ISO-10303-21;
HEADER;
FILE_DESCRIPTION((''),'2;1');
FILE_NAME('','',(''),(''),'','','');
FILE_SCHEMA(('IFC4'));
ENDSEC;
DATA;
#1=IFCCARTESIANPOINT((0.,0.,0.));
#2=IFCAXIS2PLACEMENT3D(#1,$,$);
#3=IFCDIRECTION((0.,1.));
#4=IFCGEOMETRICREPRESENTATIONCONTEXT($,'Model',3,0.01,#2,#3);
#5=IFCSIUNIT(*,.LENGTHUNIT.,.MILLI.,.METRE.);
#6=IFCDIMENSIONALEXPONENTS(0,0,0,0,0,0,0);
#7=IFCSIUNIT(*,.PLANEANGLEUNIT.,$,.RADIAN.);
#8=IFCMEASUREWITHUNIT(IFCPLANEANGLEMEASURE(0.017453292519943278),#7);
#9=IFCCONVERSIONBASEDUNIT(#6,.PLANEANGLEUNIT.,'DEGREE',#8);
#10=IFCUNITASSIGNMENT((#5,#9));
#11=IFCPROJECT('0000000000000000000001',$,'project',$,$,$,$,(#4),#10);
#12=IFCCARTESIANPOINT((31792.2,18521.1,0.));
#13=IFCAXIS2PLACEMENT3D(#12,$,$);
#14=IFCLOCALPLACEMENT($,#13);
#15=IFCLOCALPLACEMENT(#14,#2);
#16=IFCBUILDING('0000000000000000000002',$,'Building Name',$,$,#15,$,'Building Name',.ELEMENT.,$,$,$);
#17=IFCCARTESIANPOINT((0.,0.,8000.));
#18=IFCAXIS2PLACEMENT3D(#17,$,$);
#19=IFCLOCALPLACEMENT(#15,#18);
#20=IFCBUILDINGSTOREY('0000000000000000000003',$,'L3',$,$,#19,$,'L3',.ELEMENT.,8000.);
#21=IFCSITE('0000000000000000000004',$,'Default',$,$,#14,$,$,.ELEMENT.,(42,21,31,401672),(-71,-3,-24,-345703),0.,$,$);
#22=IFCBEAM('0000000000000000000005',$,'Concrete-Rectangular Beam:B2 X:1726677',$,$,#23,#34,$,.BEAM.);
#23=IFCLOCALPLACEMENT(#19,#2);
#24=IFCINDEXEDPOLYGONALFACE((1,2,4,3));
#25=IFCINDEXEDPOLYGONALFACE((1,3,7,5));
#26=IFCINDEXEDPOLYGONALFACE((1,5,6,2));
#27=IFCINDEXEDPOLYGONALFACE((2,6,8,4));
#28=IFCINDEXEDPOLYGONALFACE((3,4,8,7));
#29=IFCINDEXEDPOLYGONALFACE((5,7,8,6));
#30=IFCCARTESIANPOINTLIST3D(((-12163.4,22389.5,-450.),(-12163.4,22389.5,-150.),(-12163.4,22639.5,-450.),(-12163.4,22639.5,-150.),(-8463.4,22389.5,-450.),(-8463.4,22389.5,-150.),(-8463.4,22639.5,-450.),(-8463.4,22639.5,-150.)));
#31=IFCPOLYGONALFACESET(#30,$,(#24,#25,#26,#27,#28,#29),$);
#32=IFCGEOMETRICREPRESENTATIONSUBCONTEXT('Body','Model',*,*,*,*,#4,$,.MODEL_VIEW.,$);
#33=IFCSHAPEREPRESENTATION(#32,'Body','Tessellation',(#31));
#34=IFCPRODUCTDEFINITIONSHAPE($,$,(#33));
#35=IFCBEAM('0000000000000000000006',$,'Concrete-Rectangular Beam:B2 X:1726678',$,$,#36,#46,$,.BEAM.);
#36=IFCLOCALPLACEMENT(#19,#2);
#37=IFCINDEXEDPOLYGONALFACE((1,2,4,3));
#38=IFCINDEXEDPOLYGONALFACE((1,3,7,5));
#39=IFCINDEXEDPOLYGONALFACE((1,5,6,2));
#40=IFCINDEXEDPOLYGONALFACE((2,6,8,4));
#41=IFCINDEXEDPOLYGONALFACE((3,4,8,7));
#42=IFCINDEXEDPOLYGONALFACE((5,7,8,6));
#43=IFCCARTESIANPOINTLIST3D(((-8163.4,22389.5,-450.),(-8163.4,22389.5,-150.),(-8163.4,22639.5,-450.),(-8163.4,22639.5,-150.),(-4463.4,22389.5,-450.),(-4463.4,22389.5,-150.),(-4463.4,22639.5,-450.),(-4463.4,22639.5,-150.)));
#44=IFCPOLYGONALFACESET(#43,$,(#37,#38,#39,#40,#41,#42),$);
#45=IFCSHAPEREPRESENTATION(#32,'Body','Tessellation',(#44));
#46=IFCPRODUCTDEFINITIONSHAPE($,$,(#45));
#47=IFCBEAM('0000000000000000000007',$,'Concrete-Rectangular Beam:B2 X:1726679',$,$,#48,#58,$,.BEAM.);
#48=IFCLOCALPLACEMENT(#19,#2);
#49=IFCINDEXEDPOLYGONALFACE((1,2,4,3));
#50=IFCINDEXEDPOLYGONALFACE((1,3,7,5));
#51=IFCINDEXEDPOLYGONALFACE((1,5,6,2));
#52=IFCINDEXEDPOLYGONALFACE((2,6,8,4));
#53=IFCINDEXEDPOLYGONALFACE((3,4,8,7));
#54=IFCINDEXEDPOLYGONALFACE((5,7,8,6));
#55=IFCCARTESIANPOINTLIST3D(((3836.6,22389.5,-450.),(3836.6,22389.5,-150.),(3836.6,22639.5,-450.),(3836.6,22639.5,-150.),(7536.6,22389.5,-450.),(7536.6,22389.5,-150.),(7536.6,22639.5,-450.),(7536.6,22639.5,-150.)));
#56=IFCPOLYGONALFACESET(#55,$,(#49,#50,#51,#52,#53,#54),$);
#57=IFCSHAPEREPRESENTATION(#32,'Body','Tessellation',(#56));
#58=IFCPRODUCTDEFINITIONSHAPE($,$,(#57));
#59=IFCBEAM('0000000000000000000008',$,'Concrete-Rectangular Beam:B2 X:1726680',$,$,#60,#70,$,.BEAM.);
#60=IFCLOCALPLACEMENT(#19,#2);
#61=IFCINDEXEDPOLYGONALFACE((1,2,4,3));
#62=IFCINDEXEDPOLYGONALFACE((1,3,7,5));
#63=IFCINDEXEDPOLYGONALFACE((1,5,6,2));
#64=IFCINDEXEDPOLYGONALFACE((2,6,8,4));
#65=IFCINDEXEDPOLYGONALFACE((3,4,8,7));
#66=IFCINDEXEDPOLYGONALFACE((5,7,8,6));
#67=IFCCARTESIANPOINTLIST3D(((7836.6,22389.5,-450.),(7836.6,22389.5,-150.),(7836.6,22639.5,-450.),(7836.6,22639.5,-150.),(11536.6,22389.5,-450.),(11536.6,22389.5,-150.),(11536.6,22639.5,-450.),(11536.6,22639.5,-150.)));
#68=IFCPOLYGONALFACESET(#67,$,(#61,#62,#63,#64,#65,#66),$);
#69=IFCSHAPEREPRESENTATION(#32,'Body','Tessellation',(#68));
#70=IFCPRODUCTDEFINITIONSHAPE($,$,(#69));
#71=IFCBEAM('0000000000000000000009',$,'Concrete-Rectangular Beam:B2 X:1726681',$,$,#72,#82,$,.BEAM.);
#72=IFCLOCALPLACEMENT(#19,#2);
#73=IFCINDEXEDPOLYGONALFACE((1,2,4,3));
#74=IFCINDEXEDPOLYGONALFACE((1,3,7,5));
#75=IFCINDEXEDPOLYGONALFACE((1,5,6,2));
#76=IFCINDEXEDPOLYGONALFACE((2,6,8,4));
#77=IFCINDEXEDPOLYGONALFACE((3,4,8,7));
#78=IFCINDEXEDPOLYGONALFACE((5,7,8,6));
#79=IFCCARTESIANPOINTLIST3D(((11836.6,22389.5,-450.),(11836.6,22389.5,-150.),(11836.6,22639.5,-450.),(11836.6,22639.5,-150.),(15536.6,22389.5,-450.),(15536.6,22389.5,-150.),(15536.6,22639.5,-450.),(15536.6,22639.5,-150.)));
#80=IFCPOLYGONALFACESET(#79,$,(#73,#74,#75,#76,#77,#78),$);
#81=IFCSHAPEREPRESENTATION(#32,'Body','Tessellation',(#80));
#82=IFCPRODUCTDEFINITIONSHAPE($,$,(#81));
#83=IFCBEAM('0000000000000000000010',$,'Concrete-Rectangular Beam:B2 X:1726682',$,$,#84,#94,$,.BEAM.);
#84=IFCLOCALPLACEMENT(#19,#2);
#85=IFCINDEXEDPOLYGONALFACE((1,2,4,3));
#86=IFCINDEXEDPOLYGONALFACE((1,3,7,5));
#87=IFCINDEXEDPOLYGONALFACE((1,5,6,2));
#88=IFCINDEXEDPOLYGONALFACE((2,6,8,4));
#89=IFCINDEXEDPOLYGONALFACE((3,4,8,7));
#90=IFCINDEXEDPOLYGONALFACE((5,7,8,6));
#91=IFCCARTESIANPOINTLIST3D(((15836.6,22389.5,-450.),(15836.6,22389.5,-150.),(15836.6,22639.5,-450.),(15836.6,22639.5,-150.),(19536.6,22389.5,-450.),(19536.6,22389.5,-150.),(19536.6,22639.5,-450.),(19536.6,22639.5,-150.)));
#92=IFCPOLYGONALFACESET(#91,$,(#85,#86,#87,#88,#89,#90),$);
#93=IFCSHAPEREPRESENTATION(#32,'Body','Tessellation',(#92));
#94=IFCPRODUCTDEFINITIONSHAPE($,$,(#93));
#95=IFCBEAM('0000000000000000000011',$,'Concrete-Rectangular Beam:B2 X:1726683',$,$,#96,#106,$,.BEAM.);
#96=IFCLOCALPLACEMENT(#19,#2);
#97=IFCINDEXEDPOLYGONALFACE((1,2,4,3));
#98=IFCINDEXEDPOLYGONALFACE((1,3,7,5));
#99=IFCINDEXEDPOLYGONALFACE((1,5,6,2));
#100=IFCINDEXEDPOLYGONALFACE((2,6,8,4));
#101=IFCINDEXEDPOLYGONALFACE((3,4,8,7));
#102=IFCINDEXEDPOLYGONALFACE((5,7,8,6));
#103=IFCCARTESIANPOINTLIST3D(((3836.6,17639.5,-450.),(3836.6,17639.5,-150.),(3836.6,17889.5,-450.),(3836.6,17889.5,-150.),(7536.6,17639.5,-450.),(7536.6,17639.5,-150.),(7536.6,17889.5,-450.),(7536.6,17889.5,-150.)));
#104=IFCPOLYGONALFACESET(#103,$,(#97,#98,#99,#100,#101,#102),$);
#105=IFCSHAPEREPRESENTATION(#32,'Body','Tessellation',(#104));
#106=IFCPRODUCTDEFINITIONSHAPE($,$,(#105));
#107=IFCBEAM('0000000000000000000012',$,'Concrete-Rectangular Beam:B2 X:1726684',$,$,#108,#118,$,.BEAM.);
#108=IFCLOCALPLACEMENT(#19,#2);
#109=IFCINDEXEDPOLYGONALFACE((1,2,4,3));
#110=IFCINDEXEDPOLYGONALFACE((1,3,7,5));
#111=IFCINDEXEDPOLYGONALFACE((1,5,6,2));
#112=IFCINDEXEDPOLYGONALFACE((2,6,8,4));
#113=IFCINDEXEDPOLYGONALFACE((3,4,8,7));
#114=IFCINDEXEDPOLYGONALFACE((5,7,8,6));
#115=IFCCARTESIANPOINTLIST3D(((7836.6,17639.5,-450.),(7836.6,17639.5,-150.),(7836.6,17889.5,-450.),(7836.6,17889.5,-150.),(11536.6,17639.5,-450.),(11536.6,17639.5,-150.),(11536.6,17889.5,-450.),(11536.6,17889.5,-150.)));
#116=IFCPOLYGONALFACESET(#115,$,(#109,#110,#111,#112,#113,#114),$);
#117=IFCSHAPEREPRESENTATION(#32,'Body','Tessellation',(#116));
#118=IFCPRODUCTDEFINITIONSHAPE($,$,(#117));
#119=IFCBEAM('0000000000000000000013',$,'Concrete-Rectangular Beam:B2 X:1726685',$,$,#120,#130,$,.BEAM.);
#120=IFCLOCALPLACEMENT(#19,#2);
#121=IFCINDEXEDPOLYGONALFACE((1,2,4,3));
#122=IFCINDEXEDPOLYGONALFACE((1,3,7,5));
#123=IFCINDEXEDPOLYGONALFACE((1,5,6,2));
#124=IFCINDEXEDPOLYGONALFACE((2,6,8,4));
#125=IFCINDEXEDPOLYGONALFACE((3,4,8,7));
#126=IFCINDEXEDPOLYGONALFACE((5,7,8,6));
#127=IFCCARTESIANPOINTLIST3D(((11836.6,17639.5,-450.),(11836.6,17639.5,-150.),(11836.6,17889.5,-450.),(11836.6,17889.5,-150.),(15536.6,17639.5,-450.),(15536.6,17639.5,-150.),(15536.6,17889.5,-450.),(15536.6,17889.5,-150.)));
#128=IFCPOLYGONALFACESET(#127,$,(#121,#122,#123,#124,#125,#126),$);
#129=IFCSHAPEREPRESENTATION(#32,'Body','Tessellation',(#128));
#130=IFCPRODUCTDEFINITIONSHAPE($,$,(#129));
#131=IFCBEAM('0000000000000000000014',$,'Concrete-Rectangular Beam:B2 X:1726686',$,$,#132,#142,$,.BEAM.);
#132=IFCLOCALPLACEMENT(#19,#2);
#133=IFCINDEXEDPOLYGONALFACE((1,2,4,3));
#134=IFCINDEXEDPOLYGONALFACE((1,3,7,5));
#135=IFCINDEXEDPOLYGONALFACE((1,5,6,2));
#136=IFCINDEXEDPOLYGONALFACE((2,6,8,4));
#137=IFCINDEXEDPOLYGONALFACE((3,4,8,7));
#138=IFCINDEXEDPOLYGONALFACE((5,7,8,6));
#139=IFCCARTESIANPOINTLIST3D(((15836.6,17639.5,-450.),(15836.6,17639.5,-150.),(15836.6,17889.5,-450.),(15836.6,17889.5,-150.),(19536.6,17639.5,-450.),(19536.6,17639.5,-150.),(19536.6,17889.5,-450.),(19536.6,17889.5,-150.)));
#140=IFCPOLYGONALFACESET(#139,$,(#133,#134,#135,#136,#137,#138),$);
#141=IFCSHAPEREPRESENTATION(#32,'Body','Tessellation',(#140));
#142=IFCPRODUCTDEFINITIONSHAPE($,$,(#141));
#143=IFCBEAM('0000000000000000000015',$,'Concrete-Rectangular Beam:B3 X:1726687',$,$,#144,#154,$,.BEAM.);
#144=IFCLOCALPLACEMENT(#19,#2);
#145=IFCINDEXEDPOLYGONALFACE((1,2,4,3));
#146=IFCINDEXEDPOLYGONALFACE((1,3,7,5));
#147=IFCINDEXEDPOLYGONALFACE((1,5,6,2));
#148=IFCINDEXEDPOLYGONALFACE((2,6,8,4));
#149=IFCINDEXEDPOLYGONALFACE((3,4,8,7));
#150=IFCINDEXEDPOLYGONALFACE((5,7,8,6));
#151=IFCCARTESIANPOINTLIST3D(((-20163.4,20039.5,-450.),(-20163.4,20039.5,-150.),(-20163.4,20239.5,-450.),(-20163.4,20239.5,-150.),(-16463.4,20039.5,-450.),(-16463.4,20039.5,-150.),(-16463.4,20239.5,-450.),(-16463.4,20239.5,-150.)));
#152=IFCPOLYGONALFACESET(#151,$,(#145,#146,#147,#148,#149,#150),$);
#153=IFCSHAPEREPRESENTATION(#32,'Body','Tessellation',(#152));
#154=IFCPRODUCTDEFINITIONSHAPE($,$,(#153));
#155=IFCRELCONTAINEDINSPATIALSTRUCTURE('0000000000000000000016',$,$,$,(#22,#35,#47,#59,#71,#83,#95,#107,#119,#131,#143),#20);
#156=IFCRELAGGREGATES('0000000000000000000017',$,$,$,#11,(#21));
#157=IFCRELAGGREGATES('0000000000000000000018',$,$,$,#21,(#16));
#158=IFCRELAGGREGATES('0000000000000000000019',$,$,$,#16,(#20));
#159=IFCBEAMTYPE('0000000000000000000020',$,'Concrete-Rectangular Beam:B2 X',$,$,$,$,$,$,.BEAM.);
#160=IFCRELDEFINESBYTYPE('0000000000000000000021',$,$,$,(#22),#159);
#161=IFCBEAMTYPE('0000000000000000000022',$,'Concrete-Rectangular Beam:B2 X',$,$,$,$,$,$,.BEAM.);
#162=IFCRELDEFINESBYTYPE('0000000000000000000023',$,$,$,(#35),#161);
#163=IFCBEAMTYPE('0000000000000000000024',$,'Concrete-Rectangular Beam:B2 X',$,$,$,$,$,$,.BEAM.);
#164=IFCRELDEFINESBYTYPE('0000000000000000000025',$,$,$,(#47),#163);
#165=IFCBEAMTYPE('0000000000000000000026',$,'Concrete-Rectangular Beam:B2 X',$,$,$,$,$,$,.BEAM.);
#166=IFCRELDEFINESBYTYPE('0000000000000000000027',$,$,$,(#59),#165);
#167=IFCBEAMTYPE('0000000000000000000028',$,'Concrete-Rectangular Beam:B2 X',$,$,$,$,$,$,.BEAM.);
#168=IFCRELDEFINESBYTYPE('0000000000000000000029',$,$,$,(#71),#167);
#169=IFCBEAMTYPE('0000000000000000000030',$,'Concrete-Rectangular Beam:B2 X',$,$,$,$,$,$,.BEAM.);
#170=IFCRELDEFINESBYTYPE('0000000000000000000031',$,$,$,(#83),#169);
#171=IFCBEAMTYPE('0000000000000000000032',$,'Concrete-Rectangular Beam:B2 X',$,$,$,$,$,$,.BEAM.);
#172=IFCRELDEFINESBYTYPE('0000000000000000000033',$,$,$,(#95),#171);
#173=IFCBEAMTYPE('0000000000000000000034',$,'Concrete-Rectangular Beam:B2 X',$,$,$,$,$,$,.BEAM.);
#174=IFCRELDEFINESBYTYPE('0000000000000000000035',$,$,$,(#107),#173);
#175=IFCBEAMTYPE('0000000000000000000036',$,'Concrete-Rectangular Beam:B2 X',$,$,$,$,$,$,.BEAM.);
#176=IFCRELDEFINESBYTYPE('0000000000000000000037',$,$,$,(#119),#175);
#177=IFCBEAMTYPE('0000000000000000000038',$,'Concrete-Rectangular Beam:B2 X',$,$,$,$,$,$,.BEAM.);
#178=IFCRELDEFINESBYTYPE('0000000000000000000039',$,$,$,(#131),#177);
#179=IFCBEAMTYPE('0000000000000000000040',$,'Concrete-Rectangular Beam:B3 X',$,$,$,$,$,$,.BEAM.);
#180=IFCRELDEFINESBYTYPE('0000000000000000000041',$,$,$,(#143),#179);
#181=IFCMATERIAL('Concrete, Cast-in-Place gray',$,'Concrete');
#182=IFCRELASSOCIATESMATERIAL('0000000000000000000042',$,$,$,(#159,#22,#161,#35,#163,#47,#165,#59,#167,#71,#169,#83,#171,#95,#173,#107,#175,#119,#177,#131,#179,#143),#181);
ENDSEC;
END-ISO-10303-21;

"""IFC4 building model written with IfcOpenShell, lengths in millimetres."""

from ifc_helpers import new_model, entity, si_unit, converted_unit, direction, frame, origin, place, context, subcontext, project, spatial, indexed_curve, outline, extrude, source, transform, mapped, material, type_object, type_shapes, element, save


model = new_model("IFC4")

# Units and contexts
model_context = context("Model", 3, precision=0.01, world=origin(), true_north=direction((0.0, 1.0)))
body_context = subcontext(model_context, "Body", "Model", "MODEL_VIEW")
ifc_project = project(units=[si_unit("LENGTHUNIT", "METRE", prefix="MILLI"), converted_unit("PLANEANGLEUNIT", "DEGREE", entity("IfcPlaneAngleMeasure", 0.017453292519943278), si_unit("PLANEANGLEUNIT", "RADIAN"), dimensions=[0, 0, 0, 0, 0, 0, 0])], contexts=[model_context])

# Site, building, storey
site_placement = place(None, frame((31792.2, 18521.1, 0.0)))
site = spatial("IfcSite", under=ifc_project, at=site_placement, Name="Default", CompositionType="ELEMENT", RefLatitude=(42, 21, 31, 401672), RefLongitude=(-71, -3, -24, -345703), RefElevation=0.0)
building_placement = place(site_placement, origin())
building = spatial("IfcBuilding", under=site, at=building_placement, Name="Building Name", LongName="Building Name", CompositionType="ELEMENT")
storey_placement = place(building_placement, frame((0.0, 0.0, 8000.0)))
storey = spatial("IfcBuildingStorey", under=building, at=storey_placement, Name="L3", LongName="L3", CompositionType="ELEMENT", Elevation=8000.0)

# Beams
ifc_material = material(Name="Concrete, Cast-in-Place gray", Category="Concrete")
beam_type_1 = type_object("IfcBeamType", Name="Concrete-Rectangular Beam:B2 X", PredefinedType="BEAM", material=ifc_material)
shared_shape_1 = source(origin(), body_context, "Body", "SweptSolid", [
    extrude(outline(indexed_curve([(-150.0, -125.0), (150.0, -125.0), (150.0, 125.0), (-150.0, 125.0), (-150.0, -125.0)], self_intersect=False)), frame((-12163.4, 22514.5, 7700.0), z_axis=(1.0, 0.0, 0.0), x_axis=(0.0, 0.0, -1.0)), (0.0, 0.0, 1.0), 3700.0),
])
type_shapes(beam_type_1, [shared_shape_1])
beam_1_placement = place(storey_placement, frame((0.0, 0.0, -8000.0)))
element("IfcBeam", 1, at=beam_1_placement, inside=storey, type_object=beam_type_1, material=ifc_material, Name="Concrete-Rectangular Beam:B2 X:1726677", PredefinedType="BEAM", context=body_context, shape_type="MappedRepresentation", body=[
    mapped(shared_shape_1, transform((0.0, 0.0, 0.0), scale=1.0)),
])
beam_type_2 = type_object("IfcBeamType", Name="Concrete-Rectangular Beam:B2 X", PredefinedType="BEAM", material=ifc_material)
shared_shape_2 = source(origin(), body_context, "Body", "SweptSolid", [
    extrude(outline(indexed_curve([(-150.0, -125.0), (150.0, -125.0), (150.0, 125.0), (-150.0, 125.0), (-150.0, -125.0)], self_intersect=False)), frame((-8163.4, 22514.5, 7700.0), z_axis=(1.0, 0.0, 0.0), x_axis=(0.0, 0.0, -1.0)), (0.0, 0.0, 1.0), 3700.0),
])
type_shapes(beam_type_2, [shared_shape_2])
beam_2_placement = place(storey_placement, frame((0.0, 0.0, -8000.0)))
element("IfcBeam", 2, at=beam_2_placement, inside=storey, type_object=beam_type_2, material=ifc_material, Name="Concrete-Rectangular Beam:B2 X:1726678", PredefinedType="BEAM", context=body_context, shape_type="MappedRepresentation", body=[
    mapped(shared_shape_2, transform((0.0, 0.0, 0.0), scale=1.0)),
])
beam_type_3 = type_object("IfcBeamType", Name="Concrete-Rectangular Beam:B2 X", PredefinedType="BEAM", material=ifc_material)
shared_shape_3 = source(origin(), body_context, "Body", "SweptSolid", [
    extrude(outline(indexed_curve([(-150.0, -125.0), (150.0, -125.0), (150.0, 125.0), (-150.0, 125.0), (-150.0, -125.0)], self_intersect=False)), frame((3836.6, 22514.5, 7700.0), z_axis=(1.0, 0.0, 0.0), x_axis=(0.0, 0.0, -1.0)), (0.0, 0.0, 1.0), 3700.0),
])
type_shapes(beam_type_3, [shared_shape_3])
beam_3_placement = place(storey_placement, frame((0.0, 0.0, -8000.0)))
element("IfcBeam", 3, at=beam_3_placement, inside=storey, type_object=beam_type_3, material=ifc_material, Name="Concrete-Rectangular Beam:B2 X:1726679", PredefinedType="BEAM", context=body_context, shape_type="MappedRepresentation", body=[
    mapped(shared_shape_3, transform((0.0, 0.0, 0.0), scale=1.0)),
])
beam_type_4 = type_object("IfcBeamType", Name="Concrete-Rectangular Beam:B2 X", PredefinedType="BEAM", material=ifc_material)
shared_shape_4 = source(origin(), body_context, "Body", "SweptSolid", [
    extrude(outline(indexed_curve([(-150.0, -125.0), (150.0, -125.0), (150.0, 125.0), (-150.0, 125.0), (-150.0, -125.0)], self_intersect=False)), frame((7836.6, 22514.5, 7700.0), z_axis=(1.0, 0.0, 0.0), x_axis=(0.0, 0.0, -1.0)), (0.0, 0.0, 1.0), 3700.0),
])
type_shapes(beam_type_4, [shared_shape_4])
beam_4_placement = place(storey_placement, frame((0.0, 0.0, -8000.0)))
element("IfcBeam", 4, at=beam_4_placement, inside=storey, type_object=beam_type_4, material=ifc_material, Name="Concrete-Rectangular Beam:B2 X:1726680", PredefinedType="BEAM", context=body_context, shape_type="MappedRepresentation", body=[
    mapped(shared_shape_4, transform((0.0, 0.0, 0.0), scale=1.0)),
])
beam_type_5 = type_object("IfcBeamType", Name="Concrete-Rectangular Beam:B2 X", PredefinedType="BEAM", material=ifc_material)
shared_shape_5 = source(origin(), body_context, "Body", "SweptSolid", [
    extrude(outline(indexed_curve([(-150.0, -125.0), (150.0, -125.0), (150.0, 125.0), (-150.0, 125.0), (-150.0, -125.0)], self_intersect=False)), frame((11836.6, 22514.5, 7700.0), z_axis=(1.0, 0.0, 0.0), x_axis=(0.0, 0.0, -1.0)), (0.0, 0.0, 1.0), 3700.0),
])
type_shapes(beam_type_5, [shared_shape_5])
beam_5_placement = place(storey_placement, frame((0.0, 0.0, -8000.0)))
element("IfcBeam", 5, at=beam_5_placement, inside=storey, type_object=beam_type_5, material=ifc_material, Name="Concrete-Rectangular Beam:B2 X:1726681", PredefinedType="BEAM", context=body_context, shape_type="MappedRepresentation", body=[
    mapped(shared_shape_5, transform((0.0, 0.0, 0.0), scale=1.0)),
])
beam_type_6 = type_object("IfcBeamType", Name="Concrete-Rectangular Beam:B2 X", PredefinedType="BEAM", material=ifc_material)
shared_shape_6 = source(origin(), body_context, "Body", "SweptSolid", [
    extrude(outline(indexed_curve([(-150.0, -125.0), (150.0, -125.0), (150.0, 125.0), (-150.0, 125.0), (-150.0, -125.0)], self_intersect=False)), frame((15836.6, 22514.5, 7700.0), z_axis=(1.0, 0.0, 0.0), x_axis=(0.0, 0.0, -1.0)), (0.0, 0.0, 1.0), 3700.0),
])
type_shapes(beam_type_6, [shared_shape_6])
beam_6_placement = place(storey_placement, frame((0.0, 0.0, -8000.0)))
element("IfcBeam", 6, at=beam_6_placement, inside=storey, type_object=beam_type_6, material=ifc_material, Name="Concrete-Rectangular Beam:B2 X:1726682", PredefinedType="BEAM", context=body_context, shape_type="MappedRepresentation", body=[
    mapped(shared_shape_6, transform((0.0, 0.0, 0.0), scale=1.0)),
])
beam_type_7 = type_object("IfcBeamType", Name="Concrete-Rectangular Beam:B2 X", PredefinedType="BEAM", material=ifc_material)
shared_shape_7 = source(origin(), body_context, "Body", "SweptSolid", [
    extrude(outline(indexed_curve([(-150.0, -125.0), (150.0, -125.0), (150.0, 125.0), (-150.0, 125.0), (-150.0, -125.0)], self_intersect=False)), frame((3836.6, 17764.5, 7700.0), z_axis=(1.0, 0.0, 0.0), x_axis=(0.0, 0.0, -1.0)), (0.0, 0.0, 1.0), 3700.0),
])
type_shapes(beam_type_7, [shared_shape_7])
beam_7_placement = place(storey_placement, frame((0.0, 0.0, -8000.0)))
element("IfcBeam", 7, at=beam_7_placement, inside=storey, type_object=beam_type_7, material=ifc_material, Name="Concrete-Rectangular Beam:B2 X:1726683", PredefinedType="BEAM", context=body_context, shape_type="MappedRepresentation", body=[
    mapped(shared_shape_7, transform((0.0, 0.0, 0.0), scale=1.0)),
])
beam_type_8 = type_object("IfcBeamType", Name="Concrete-Rectangular Beam:B2 X", PredefinedType="BEAM", material=ifc_material)
shared_shape_8 = source(origin(), body_context, "Body", "SweptSolid", [
    extrude(outline(indexed_curve([(-150.0, -125.0), (150.0, -125.0), (150.0, 125.0), (-150.0, 125.0), (-150.0, -125.0)], self_intersect=False)), frame((7836.6, 17764.5, 7700.0), z_axis=(1.0, 0.0, 0.0), x_axis=(0.0, 0.0, -1.0)), (0.0, 0.0, 1.0), 3700.0),
])
type_shapes(beam_type_8, [shared_shape_8])
beam_8_placement = place(storey_placement, frame((0.0, 0.0, -8000.0)))
element("IfcBeam", 8, at=beam_8_placement, inside=storey, type_object=beam_type_8, material=ifc_material, Name="Concrete-Rectangular Beam:B2 X:1726684", PredefinedType="BEAM", context=body_context, shape_type="MappedRepresentation", body=[
    mapped(shared_shape_8, transform((0.0, 0.0, 0.0), scale=1.0)),
])
beam_type_9 = type_object("IfcBeamType", Name="Concrete-Rectangular Beam:B2 X", PredefinedType="BEAM", material=ifc_material)
shared_shape_9 = source(origin(), body_context, "Body", "SweptSolid", [
    extrude(outline(indexed_curve([(-150.0, -125.0), (150.0, -125.0), (150.0, 125.0), (-150.0, 125.0), (-150.0, -125.0)], self_intersect=False)), frame((11836.6, 17764.5, 7700.0), z_axis=(1.0, 0.0, 0.0), x_axis=(0.0, 0.0, -1.0)), (0.0, 0.0, 1.0), 3700.0),
])
type_shapes(beam_type_9, [shared_shape_9])
beam_9_placement = place(storey_placement, frame((0.0, 0.0, -8000.0)))
element("IfcBeam", 9, at=beam_9_placement, inside=storey, type_object=beam_type_9, material=ifc_material, Name="Concrete-Rectangular Beam:B2 X:1726685", PredefinedType="BEAM", context=body_context, shape_type="MappedRepresentation", body=[
    mapped(shared_shape_9, transform((0.0, 0.0, 0.0), scale=1.0)),
])
beam_type_10 = type_object("IfcBeamType", Name="Concrete-Rectangular Beam:B2 X", PredefinedType="BEAM", material=ifc_material)
shared_shape_10 = source(origin(), body_context, "Body", "SweptSolid", [
    extrude(outline(indexed_curve([(-150.0, -125.0), (150.0, -125.0), (150.0, 125.0), (-150.0, 125.0), (-150.0, -125.0)], self_intersect=False)), frame((15836.6, 17764.5, 7700.0), z_axis=(1.0, 0.0, 0.0), x_axis=(0.0, 0.0, -1.0)), (0.0, 0.0, 1.0), 3700.0),
])
type_shapes(beam_type_10, [shared_shape_10])
beam_10_placement = place(storey_placement, frame((0.0, 0.0, -8000.0)))
element("IfcBeam", 10, at=beam_10_placement, inside=storey, type_object=beam_type_10, material=ifc_material, Name="Concrete-Rectangular Beam:B2 X:1726686", PredefinedType="BEAM", context=body_context, shape_type="MappedRepresentation", body=[
    mapped(shared_shape_10, transform((0.0, 0.0, 0.0), scale=1.0)),
])
beam_type_11 = type_object("IfcBeamType", Name="Concrete-Rectangular Beam:B3 X", PredefinedType="BEAM", material=ifc_material)
shared_shape_11 = source(origin(), body_context, "Body", "SweptSolid", [
    extrude(outline(indexed_curve([(-150.0, -100.0), (150.0, -100.0), (150.0, 100.0), (-150.0, 100.0), (-150.0, -100.0)], self_intersect=False)), frame((-20163.4, 20139.5, 7700.0), z_axis=(1.0, 0.0, 0.0), x_axis=(0.0, 0.0, -1.0)), (0.0, 0.0, 1.0), 3700.0),
])
type_shapes(beam_type_11, [shared_shape_11])
beam_11_placement = place(storey_placement, frame((0.0, 0.0, -8000.0)))
element("IfcBeam", 11, at=beam_11_placement, inside=storey, type_object=beam_type_11, material=ifc_material, Name="Concrete-Rectangular Beam:B3 X:1726687", PredefinedType="BEAM", context=body_context, shape_type="MappedRepresentation", body=[
    mapped(shared_shape_11, transform((0.0, 0.0, 0.0), scale=1.0)),
])

save(model, "model.ifc")
